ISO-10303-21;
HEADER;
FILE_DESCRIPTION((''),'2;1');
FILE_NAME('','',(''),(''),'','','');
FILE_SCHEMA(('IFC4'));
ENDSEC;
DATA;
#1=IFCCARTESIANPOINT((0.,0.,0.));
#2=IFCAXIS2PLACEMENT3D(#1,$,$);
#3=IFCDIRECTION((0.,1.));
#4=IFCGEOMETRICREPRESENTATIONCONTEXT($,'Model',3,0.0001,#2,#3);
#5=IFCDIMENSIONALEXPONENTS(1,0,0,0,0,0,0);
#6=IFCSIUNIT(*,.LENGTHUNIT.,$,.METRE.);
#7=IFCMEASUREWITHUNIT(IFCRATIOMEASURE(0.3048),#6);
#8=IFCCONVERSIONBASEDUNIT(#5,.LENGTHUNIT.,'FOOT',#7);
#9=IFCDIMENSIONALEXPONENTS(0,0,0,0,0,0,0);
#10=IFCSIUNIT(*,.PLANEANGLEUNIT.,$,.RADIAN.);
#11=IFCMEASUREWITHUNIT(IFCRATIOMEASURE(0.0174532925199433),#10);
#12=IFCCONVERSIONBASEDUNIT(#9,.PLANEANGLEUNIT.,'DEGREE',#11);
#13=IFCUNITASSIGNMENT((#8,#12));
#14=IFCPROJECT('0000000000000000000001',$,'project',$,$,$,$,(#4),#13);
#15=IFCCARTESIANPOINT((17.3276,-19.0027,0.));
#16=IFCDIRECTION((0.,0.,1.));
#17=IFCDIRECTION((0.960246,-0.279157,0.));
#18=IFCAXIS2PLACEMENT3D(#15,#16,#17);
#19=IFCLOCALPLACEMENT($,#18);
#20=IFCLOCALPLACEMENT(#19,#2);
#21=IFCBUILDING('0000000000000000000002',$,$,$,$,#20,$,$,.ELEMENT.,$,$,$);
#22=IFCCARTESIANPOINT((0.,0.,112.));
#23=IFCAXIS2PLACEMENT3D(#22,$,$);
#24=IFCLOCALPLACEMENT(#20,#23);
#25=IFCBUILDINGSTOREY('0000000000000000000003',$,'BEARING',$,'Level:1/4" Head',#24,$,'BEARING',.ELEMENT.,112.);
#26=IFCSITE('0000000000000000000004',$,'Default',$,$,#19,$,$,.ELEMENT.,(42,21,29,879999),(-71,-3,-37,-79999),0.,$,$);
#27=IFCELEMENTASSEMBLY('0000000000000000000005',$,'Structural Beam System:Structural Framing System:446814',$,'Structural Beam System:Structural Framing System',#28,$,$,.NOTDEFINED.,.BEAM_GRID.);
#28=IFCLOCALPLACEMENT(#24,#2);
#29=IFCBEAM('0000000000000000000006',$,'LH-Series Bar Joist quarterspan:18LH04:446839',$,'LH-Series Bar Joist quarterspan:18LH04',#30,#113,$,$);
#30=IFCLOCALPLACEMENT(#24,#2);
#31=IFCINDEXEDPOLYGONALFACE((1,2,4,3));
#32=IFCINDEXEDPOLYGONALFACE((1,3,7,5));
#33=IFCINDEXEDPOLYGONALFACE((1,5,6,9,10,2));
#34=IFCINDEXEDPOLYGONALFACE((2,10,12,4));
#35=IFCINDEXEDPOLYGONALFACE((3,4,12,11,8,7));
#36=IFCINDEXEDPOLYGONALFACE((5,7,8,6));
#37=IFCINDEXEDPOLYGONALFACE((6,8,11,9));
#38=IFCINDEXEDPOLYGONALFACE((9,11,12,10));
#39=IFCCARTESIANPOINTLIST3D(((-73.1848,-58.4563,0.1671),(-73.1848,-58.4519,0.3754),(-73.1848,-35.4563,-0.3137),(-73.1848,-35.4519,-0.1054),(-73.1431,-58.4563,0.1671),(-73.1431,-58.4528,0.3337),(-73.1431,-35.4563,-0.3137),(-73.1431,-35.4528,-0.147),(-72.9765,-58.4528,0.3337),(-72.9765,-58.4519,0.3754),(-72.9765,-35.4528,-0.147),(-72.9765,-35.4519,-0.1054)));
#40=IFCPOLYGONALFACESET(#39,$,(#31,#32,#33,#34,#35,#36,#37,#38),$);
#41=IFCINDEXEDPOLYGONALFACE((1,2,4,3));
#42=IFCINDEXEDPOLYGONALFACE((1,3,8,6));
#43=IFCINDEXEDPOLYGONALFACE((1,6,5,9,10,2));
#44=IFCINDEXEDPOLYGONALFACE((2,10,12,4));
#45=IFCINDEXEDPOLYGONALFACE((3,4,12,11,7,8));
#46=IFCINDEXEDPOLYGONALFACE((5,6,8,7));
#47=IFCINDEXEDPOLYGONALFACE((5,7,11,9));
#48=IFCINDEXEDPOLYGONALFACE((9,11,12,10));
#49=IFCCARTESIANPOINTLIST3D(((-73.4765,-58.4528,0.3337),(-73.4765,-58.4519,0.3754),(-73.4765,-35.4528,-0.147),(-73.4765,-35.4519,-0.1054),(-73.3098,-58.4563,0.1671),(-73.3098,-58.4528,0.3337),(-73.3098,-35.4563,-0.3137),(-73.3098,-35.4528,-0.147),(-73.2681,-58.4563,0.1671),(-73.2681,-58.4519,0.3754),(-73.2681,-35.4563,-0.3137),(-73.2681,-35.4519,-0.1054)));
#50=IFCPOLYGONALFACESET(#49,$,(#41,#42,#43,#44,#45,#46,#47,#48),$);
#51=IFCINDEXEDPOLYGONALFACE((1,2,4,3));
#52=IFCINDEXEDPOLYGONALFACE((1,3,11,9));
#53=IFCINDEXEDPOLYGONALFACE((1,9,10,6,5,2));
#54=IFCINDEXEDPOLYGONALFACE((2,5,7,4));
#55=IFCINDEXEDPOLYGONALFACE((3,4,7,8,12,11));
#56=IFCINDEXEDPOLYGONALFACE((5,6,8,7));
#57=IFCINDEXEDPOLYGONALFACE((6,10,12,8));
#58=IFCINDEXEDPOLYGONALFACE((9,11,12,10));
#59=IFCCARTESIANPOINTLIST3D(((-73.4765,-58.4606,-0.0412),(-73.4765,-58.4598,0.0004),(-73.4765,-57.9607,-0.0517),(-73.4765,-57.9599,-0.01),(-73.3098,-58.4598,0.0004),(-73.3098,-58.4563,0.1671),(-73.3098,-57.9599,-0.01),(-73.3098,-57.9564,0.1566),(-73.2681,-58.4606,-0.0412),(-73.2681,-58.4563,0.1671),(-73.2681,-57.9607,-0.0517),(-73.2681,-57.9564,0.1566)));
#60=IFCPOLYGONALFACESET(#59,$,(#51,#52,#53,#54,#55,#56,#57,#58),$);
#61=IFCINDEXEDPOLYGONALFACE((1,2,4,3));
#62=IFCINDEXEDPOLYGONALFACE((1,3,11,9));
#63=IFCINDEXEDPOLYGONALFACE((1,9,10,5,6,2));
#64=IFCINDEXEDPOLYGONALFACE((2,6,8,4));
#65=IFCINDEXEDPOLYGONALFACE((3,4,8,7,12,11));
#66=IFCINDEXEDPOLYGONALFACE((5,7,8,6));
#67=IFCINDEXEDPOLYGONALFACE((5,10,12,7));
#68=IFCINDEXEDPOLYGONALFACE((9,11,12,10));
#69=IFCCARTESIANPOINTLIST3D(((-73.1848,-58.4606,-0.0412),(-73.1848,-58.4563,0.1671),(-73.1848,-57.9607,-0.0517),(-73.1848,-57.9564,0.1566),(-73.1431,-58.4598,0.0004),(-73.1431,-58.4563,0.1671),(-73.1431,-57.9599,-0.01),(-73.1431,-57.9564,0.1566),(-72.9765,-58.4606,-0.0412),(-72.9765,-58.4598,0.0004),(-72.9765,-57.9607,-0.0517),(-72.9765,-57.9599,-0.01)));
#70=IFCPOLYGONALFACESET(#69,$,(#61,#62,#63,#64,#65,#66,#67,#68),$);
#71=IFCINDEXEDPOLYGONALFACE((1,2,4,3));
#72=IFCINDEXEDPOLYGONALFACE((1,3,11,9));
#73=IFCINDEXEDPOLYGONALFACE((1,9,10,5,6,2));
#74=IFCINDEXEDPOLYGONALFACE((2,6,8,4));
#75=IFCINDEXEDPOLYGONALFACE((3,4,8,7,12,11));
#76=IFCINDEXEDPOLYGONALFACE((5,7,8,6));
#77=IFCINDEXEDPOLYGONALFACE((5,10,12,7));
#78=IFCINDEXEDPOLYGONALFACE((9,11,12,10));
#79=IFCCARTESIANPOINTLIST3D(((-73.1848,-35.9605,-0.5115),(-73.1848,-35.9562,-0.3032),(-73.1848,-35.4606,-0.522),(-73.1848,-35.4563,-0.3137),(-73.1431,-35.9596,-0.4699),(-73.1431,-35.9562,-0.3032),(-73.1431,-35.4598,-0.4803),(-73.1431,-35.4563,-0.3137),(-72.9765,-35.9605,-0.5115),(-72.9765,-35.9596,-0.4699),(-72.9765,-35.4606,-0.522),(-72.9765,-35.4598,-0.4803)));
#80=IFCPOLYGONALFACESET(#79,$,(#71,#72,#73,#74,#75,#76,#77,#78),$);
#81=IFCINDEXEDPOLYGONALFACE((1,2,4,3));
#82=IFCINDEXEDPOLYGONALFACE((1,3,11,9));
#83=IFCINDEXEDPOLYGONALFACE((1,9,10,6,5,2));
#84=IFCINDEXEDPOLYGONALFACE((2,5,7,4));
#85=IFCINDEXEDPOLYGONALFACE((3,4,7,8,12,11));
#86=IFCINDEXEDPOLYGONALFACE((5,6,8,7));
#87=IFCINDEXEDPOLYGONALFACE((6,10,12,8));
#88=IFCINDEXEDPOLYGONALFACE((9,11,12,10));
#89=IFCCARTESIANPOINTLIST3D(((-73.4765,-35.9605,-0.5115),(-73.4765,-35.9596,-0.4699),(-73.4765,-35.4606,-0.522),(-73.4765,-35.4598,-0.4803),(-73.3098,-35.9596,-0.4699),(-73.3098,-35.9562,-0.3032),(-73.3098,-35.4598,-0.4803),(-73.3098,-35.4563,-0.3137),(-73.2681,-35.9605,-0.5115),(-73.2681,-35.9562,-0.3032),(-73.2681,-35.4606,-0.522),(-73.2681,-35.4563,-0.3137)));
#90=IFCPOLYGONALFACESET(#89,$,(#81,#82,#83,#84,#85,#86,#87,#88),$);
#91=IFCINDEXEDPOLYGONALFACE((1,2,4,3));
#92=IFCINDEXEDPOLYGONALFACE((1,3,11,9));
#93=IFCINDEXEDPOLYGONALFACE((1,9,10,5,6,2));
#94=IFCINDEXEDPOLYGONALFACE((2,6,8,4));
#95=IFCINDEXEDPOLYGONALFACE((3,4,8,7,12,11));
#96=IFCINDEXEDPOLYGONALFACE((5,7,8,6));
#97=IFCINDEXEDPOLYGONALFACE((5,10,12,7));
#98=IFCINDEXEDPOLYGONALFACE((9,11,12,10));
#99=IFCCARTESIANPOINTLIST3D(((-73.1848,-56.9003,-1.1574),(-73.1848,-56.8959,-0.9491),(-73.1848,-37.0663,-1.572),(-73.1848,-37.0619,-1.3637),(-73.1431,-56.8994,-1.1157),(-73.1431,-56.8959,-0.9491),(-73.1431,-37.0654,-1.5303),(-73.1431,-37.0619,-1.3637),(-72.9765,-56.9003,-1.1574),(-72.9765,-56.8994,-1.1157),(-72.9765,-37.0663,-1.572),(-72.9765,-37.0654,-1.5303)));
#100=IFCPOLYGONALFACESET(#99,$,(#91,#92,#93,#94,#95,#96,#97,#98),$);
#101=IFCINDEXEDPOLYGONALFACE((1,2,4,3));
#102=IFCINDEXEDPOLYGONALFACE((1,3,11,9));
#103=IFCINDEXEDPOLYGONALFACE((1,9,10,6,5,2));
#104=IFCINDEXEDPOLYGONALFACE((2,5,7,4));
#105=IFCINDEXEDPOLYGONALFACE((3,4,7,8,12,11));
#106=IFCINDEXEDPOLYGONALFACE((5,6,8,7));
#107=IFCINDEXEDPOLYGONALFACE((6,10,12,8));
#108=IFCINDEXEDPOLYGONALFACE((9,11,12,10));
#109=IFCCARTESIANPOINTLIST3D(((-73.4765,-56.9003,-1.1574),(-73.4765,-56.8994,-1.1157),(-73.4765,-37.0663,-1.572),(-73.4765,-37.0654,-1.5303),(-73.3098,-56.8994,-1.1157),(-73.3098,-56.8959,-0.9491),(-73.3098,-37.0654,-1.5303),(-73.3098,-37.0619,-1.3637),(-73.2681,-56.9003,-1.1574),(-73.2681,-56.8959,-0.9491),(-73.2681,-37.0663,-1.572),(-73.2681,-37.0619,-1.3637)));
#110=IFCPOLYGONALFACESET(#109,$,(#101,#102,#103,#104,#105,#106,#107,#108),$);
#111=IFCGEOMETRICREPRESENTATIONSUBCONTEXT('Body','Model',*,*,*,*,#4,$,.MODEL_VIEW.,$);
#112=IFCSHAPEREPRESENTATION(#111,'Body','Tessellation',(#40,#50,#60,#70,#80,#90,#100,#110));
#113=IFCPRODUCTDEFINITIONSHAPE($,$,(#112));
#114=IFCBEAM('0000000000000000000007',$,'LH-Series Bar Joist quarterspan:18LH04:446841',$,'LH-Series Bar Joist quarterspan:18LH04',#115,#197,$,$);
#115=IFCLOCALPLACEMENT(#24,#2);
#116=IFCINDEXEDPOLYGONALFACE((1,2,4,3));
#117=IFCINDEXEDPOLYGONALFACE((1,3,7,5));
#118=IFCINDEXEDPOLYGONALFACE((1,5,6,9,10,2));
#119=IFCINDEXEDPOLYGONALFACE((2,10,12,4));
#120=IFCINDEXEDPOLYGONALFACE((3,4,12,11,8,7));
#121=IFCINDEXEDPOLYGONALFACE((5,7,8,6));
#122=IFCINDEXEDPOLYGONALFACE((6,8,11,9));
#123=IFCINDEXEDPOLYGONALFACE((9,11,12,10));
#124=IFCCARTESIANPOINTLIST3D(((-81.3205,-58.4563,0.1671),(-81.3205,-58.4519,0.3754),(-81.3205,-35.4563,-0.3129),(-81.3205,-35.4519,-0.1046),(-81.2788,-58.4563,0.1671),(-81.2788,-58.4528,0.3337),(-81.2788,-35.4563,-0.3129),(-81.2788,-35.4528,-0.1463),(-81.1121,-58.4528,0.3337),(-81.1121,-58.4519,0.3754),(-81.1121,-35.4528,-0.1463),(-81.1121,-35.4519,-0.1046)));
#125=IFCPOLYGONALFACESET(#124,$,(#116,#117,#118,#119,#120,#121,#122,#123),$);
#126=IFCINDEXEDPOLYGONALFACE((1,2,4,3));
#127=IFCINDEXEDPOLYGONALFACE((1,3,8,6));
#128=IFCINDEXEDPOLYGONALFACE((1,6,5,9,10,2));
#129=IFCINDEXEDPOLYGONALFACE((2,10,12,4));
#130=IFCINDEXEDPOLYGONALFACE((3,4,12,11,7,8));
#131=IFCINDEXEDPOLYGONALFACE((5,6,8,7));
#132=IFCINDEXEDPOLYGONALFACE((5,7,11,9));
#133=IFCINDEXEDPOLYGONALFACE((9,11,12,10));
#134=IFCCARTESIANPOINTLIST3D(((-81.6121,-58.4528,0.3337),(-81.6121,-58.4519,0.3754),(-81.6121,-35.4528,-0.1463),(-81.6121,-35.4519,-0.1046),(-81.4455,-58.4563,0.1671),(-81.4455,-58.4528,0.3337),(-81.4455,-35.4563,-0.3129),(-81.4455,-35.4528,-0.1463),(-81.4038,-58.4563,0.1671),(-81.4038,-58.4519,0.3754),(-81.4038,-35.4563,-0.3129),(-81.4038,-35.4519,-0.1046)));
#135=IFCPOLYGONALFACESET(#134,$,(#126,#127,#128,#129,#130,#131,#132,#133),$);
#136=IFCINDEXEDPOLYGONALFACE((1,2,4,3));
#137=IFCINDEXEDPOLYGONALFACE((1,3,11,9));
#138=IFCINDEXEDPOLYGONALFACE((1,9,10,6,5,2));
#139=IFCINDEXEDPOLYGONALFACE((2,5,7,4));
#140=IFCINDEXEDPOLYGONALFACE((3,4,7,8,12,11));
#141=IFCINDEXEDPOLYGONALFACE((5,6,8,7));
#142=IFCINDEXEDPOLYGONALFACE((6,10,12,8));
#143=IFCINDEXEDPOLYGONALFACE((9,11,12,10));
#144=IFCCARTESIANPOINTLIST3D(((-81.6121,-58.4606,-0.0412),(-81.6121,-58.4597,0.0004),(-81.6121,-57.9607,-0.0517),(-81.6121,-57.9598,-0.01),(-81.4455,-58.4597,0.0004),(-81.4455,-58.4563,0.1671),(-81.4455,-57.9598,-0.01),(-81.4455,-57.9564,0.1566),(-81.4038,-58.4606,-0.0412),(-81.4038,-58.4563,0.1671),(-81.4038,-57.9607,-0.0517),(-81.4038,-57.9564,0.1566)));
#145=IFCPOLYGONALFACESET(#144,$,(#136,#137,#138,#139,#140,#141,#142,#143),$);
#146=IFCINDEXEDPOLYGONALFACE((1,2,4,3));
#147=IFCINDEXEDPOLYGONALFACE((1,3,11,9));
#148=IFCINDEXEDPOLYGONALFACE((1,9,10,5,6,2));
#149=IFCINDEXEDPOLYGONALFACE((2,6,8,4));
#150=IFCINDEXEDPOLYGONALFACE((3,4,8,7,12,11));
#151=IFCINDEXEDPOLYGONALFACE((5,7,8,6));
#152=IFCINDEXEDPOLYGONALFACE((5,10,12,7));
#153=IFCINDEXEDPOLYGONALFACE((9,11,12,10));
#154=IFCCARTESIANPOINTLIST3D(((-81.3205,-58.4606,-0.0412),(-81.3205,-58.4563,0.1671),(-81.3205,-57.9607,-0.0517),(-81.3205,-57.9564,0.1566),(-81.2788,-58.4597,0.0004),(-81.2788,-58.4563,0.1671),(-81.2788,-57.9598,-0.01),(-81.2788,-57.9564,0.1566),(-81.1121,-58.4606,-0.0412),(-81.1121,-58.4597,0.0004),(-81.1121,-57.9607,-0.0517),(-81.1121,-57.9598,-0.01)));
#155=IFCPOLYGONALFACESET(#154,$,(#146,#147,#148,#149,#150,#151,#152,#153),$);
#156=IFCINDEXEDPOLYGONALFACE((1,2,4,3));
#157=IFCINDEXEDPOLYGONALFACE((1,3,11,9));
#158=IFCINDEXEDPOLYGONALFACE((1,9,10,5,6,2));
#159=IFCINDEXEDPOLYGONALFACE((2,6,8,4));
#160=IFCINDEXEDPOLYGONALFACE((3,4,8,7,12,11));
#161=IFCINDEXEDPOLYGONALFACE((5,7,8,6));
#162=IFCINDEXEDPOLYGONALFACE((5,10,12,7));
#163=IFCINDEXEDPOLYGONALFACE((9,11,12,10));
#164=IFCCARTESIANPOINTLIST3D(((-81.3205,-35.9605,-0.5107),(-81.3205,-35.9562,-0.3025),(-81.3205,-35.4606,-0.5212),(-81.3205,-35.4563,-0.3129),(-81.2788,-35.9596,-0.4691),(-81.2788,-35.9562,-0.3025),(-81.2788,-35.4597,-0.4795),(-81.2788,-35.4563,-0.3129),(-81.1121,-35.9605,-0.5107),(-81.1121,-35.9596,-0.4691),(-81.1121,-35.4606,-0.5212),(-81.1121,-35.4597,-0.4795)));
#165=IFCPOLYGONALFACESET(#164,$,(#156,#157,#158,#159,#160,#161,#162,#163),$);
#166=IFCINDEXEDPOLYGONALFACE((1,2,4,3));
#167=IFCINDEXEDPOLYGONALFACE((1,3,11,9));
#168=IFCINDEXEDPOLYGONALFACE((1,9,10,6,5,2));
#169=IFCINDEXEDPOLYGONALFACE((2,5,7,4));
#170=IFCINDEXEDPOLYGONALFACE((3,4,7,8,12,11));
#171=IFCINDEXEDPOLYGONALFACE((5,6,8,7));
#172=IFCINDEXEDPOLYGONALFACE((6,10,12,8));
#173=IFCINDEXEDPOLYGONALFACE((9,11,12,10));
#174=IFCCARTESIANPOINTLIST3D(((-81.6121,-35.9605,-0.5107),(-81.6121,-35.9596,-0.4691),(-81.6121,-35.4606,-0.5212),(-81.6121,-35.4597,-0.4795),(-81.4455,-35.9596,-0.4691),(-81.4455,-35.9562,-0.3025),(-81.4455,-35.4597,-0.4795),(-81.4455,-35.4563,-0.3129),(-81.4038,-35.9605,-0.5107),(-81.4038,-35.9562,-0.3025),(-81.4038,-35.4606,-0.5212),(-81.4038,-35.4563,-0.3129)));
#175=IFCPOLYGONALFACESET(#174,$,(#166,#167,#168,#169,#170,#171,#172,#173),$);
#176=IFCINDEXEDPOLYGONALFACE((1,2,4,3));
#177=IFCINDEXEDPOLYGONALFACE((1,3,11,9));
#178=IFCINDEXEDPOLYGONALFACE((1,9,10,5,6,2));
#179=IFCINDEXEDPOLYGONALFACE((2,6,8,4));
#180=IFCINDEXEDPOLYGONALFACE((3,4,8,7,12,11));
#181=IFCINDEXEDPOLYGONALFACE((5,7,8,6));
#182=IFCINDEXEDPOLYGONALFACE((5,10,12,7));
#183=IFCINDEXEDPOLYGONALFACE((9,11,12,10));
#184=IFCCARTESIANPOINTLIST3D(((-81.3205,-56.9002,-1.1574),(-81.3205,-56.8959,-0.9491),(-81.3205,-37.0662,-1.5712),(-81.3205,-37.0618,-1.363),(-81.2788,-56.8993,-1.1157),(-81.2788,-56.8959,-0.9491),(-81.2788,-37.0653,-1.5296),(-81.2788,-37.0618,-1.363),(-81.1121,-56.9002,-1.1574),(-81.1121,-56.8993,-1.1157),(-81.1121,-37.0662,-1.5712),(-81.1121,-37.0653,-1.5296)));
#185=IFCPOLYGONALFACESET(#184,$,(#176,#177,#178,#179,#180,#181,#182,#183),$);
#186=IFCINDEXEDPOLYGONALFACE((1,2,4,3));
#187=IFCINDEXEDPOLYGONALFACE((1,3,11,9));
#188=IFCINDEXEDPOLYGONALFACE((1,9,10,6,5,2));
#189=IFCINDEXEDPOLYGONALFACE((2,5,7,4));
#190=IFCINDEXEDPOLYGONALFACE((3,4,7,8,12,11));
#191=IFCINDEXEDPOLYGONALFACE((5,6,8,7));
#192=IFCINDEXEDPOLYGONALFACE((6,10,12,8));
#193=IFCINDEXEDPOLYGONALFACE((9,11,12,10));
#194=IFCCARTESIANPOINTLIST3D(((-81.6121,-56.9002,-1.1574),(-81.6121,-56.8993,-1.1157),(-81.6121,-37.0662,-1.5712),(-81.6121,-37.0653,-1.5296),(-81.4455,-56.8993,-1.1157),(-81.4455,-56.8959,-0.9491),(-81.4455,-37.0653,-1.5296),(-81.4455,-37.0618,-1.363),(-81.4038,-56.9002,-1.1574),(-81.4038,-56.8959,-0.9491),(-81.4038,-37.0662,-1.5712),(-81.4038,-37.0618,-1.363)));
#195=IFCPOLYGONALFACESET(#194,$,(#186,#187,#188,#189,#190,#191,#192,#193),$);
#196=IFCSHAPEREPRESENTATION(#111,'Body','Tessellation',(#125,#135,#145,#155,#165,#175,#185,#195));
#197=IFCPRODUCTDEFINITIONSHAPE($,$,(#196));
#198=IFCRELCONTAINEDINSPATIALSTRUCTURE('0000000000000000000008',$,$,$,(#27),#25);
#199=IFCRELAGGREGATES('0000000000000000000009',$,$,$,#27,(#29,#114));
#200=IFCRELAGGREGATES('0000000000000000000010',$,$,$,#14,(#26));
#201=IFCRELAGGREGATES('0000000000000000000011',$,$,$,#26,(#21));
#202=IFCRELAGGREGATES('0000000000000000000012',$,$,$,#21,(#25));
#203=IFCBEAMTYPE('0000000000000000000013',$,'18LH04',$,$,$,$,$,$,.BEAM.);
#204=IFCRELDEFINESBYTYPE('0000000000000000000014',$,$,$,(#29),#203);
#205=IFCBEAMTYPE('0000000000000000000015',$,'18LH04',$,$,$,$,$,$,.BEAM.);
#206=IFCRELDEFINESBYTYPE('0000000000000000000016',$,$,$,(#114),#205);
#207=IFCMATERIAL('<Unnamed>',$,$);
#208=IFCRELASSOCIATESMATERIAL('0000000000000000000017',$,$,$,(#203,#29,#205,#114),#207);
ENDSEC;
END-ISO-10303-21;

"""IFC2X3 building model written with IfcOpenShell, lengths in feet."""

from ifc_helpers import new_model, entity, si_unit, converted_unit, direction, frame, origin, place, context, subcontext, project, spatial, polyline, outline, extrude, source, transform, mapped, material, type_object, type_shapes, element, aggregate, save


model = new_model("IFC2X3")

# Units and contexts
model_context = context("Model", 3, precision=0.0001, world=origin(), true_north=direction((0.0, 1.0)))
body_context = subcontext(model_context, "Body", "Model", "MODEL_VIEW")
ifc_project = project(units=[converted_unit("LENGTHUNIT", "FOOT", entity("IfcRatioMeasure", 0.3048), si_unit("LENGTHUNIT", "METRE"), dimensions=[1, 0, 0, 0, 0, 0, 0]), converted_unit("PLANEANGLEUNIT", "DEGREE", entity("IfcRatioMeasure", 0.0174532925199433), si_unit("PLANEANGLEUNIT", "RADIAN"), dimensions=[0, 0, 0, 0, 0, 0, 0])], contexts=[model_context])

# Site, building, storey
site_placement = place(None, frame((17.3276, -19.0027, 0.0), z_axis=(0.0, 0.0, 1.0), x_axis=(0.960246, -0.279157, 0.0)))
site = spatial("IfcSite", under=ifc_project, at=site_placement, Name="Default", CompositionType="ELEMENT", RefLatitude=(42, 21, 29, 879999), RefLongitude=(-71, -3, -37, -79999), RefElevation=0.0)
building_placement = place(site_placement, origin())
building = spatial("IfcBuilding", under=site, at=building_placement, CompositionType="ELEMENT")
storey_placement = place(building_placement, frame((0.0, 0.0, 112.0)))
storey = spatial("IfcBuildingStorey", under=building, at=storey_placement, Name="BEARING", ObjectType="Level:1/4\" Head", LongName="BEARING", CompositionType="ELEMENT", Elevation=112.0)

# Element assembly, beams
assembly_placement = place(storey_placement, origin())
assembly = element("IfcElementAssembly", 1, at=assembly_placement, inside=storey, Name="Structural Beam System:Structural Framing System:446814", ObjectType="Structural Beam System:Structural Framing System", AssemblyPlace="NOTDEFINED", PredefinedType="BEAM_GRID")
ifc_material_1 = material(Name="<Unnamed>")
beam_type_1 = type_object("IfcBeamType", Name="18LH04", PredefinedType="BEAM", material=ifc_material_1)
shared_shape_1 = source(origin(), body_context, "Body", "SweptSolid", [
    extrude(outline(polyline([(-0.0833, -0.125), (-0.0417, -0.125), (-0.0417, 0.0417), (0.125, 0.0417), (0.125, 0.0833), (-0.0833, 0.0833), (-0.0833, -0.125)])), frame((-11.5025, -0.125, 0.6667), z_axis=(1.0, 0.0, 0.0), x_axis=(0.0, 0.0, -1.0)), (0.0, 0.0, 1.0), 23.005),
    extrude(outline(polyline([(-0.0833, -0.0833), (0.125, -0.0833), (0.125, -0.0417), (-0.0417, -0.0417), (-0.0417, 0.125), (-0.0833, 0.125), (-0.0833, -0.0833)])), frame((-11.5025, 0.125, 0.6667), z_axis=(1.0, 0.0, 0.0), x_axis=(0.0, 0.0, -1.0)), (0.0, 0.0, 1.0), 23.005),
    extrude(outline(polyline([(-0.125, -0.0833), (0.0833, -0.0833), (0.0833, 0.125), (0.0417, 0.125), (0.0417, -0.0417), (-0.125, -0.0417), (-0.125, -0.0833)])), frame((-11.5025, 0.125, 0.4167), z_axis=(1.0, 0.0, 0.0), x_axis=(0.0, 0.0, -1.0)), (0.0, 0.0, 1.0), 0.5),
    extrude(outline(polyline([(0.0417, -0.125), (0.0833, -0.125), (0.0833, 0.0833), (-0.125, 0.0833), (-0.125, 0.0417), (0.0417, 0.0417), (0.0417, -0.125)])), frame((-11.5025, -0.125, 0.4167), z_axis=(1.0, 0.0, 0.0), x_axis=(0.0, 0.0, -1.0)), (0.0, 0.0, 1.0), 0.5),
    extrude(outline(polyline([(0.0417, -0.125), (0.0833, -0.125), (0.0833, 0.0833), (-0.125, 0.0833), (-0.125, 0.0417), (0.0417, 0.0417), (0.0417, -0.125)])), frame((11.0025, -0.125, 0.4167), z_axis=(1.0, 0.0, 0.0), x_axis=(0.0, 0.0, -1.0)), (0.0, 0.0, 1.0), 0.5),
    extrude(outline(polyline([(-0.125, -0.0833), (0.0833, -0.0833), (0.0833, 0.125), (0.0417, 0.125), (0.0417, -0.0417), (-0.125, -0.0417), (-0.125, -0.0833)])), frame((11.0025, 0.125, 0.4167), z_axis=(1.0, 0.0, 0.0), x_axis=(0.0, 0.0, -1.0)), (0.0, 0.0, 1.0), 0.5),
    extrude(outline(polyline([(0.0417, -0.125), (0.0833, -0.125), (0.0833, 0.0833), (-0.125, 0.0833), (-0.125, 0.0417), (0.0417, 0.0417), (0.0417, -0.125)])), frame((-9.9192, -0.125, -0.6667), z_axis=(1.0, 0.0, 0.0), x_axis=(0.0, 0.0, -1.0)), (0.0, 0.0, 1.0), 19.8384),
    extrude(outline(polyline([(-0.125, -0.0833), (0.0833, -0.0833), (0.0833, 0.125), (0.0417, 0.125), (0.0417, -0.0417), (-0.125, -0.0417), (-0.125, -0.0833)])), frame((-9.9192, 0.125, -0.6667), z_axis=(1.0, 0.0, 0.0), x_axis=(0.0, 0.0, -1.0)), (0.0, 0.0, 1.0), 19.8384),
])
type_shapes(beam_type_1, [shared_shape_1])
beam_1_placement = place(assembly_placement, frame((-73.2265, -46.9676, -0.6149), z_axis=(0.0, 0.020897, 0.999782), x_axis=(0.0, 0.999782, -0.020897)))
beam_1 = element("IfcBeam", 2, at=beam_1_placement, type_object=beam_type_1, material=ifc_material_1, Name="LH-Series Bar Joist quarterspan:18LH04:446839", ObjectType="LH-Series Bar Joist quarterspan:18LH04", context=body_context, shape_type="MappedRepresentation", body=[
    mapped(shared_shape_1, transform((0.0, 0.0, 0.0), scale=1.0)),
])
beam_type_2 = type_object("IfcBeamType", Name="18LH04", PredefinedType="BEAM", material=ifc_material_1)
shared_shape_2 = source(origin(), body_context, "Body", "SweptSolid", [
    extrude(outline(polyline([(-0.0833, -0.125), (-0.0417, -0.125), (-0.0417, 0.0417), (0.125, 0.0417), (0.125, 0.0833), (-0.0833, 0.0833), (-0.0833, -0.125)])), frame((-11.5025, -0.125, 0.6667), z_axis=(1.0, 0.0, 0.0), x_axis=(0.0, 0.0, -1.0)), (0.0, 0.0, 1.0), 23.005),
    extrude(outline(polyline([(-0.0833, -0.0833), (0.125, -0.0833), (0.125, -0.0417), (-0.0417, -0.0417), (-0.0417, 0.125), (-0.0833, 0.125), (-0.0833, -0.0833)])), frame((-11.5025, 0.125, 0.6667), z_axis=(1.0, 0.0, 0.0), x_axis=(0.0, 0.0, -1.0)), (0.0, 0.0, 1.0), 23.005),
    extrude(outline(polyline([(-0.125, -0.0833), (0.0833, -0.0833), (0.0833, 0.125), (0.0417, 0.125), (0.0417, -0.0417), (-0.125, -0.0417), (-0.125, -0.0833)])), frame((-11.5025, 0.125, 0.4167), z_axis=(1.0, 0.0, 0.0), x_axis=(0.0, 0.0, -1.0)), (0.0, 0.0, 1.0), 0.5),
    extrude(outline(polyline([(0.0417, -0.125), (0.0833, -0.125), (0.0833, 0.0833), (-0.125, 0.0833), (-0.125, 0.0417), (0.0417, 0.0417), (0.0417, -0.125)])), frame((-11.5025, -0.125, 0.4167), z_axis=(1.0, 0.0, 0.0), x_axis=(0.0, 0.0, -1.0)), (0.0, 0.0, 1.0), 0.5),
    extrude(outline(polyline([(0.0417, -0.125), (0.0833, -0.125), (0.0833, 0.0833), (-0.125, 0.0833), (-0.125, 0.0417), (0.0417, 0.0417), (0.0417, -0.125)])), frame((11.0025, -0.125, 0.4167), z_axis=(1.0, 0.0, 0.0), x_axis=(0.0, 0.0, -1.0)), (0.0, 0.0, 1.0), 0.5),
    extrude(outline(polyline([(-0.125, -0.0833), (0.0833, -0.0833), (0.0833, 0.125), (0.0417, 0.125), (0.0417, -0.0417), (-0.125, -0.0417), (-0.125, -0.0833)])), frame((11.0025, 0.125, 0.4167), z_axis=(1.0, 0.0, 0.0), x_axis=(0.0, 0.0, -1.0)), (0.0, 0.0, 1.0), 0.5),
    extrude(outline(polyline([(0.0417, -0.125), (0.0833, -0.125), (0.0833, 0.0833), (-0.125, 0.0833), (-0.125, 0.0417), (0.0417, 0.0417), (0.0417, -0.125)])), frame((-9.9192, -0.125, -0.6667), z_axis=(1.0, 0.0, 0.0), x_axis=(0.0, 0.0, -1.0)), (0.0, 0.0, 1.0), 19.8383),
    extrude(outline(polyline([(-0.125, -0.0833), (0.0833, -0.0833), (0.0833, 0.125), (0.0417, 0.125), (0.0417, -0.0417), (-0.125, -0.0417), (-0.125, -0.0833)])), frame((-9.9192, 0.125, -0.6667), z_axis=(1.0, 0.0, 0.0), x_axis=(0.0, 0.0, -1.0)), (0.0, 0.0, 1.0), 19.8383),
])
type_shapes(beam_type_2, [shared_shape_2])
beam_2_placement = place(assembly_placement, frame((-81.3621, -46.9676, -0.6145), z_axis=(0.0, 0.020863, 0.999782), x_axis=(0.0, 0.999782, -0.020863)))
beam_2 = element("IfcBeam", 3, at=beam_2_placement, type_object=beam_type_2, material=ifc_material_1, Name="LH-Series Bar Joist quarterspan:18LH04:446841", ObjectType="LH-Series Bar Joist quarterspan:18LH04", context=body_context, shape_type="MappedRepresentation", body=[
    mapped(shared_shape_2, transform((0.0, 0.0, 0.0), scale=1.0)),
])
aggregate(assembly, [beam_1, beam_2])

save(model, "model.ifc")
